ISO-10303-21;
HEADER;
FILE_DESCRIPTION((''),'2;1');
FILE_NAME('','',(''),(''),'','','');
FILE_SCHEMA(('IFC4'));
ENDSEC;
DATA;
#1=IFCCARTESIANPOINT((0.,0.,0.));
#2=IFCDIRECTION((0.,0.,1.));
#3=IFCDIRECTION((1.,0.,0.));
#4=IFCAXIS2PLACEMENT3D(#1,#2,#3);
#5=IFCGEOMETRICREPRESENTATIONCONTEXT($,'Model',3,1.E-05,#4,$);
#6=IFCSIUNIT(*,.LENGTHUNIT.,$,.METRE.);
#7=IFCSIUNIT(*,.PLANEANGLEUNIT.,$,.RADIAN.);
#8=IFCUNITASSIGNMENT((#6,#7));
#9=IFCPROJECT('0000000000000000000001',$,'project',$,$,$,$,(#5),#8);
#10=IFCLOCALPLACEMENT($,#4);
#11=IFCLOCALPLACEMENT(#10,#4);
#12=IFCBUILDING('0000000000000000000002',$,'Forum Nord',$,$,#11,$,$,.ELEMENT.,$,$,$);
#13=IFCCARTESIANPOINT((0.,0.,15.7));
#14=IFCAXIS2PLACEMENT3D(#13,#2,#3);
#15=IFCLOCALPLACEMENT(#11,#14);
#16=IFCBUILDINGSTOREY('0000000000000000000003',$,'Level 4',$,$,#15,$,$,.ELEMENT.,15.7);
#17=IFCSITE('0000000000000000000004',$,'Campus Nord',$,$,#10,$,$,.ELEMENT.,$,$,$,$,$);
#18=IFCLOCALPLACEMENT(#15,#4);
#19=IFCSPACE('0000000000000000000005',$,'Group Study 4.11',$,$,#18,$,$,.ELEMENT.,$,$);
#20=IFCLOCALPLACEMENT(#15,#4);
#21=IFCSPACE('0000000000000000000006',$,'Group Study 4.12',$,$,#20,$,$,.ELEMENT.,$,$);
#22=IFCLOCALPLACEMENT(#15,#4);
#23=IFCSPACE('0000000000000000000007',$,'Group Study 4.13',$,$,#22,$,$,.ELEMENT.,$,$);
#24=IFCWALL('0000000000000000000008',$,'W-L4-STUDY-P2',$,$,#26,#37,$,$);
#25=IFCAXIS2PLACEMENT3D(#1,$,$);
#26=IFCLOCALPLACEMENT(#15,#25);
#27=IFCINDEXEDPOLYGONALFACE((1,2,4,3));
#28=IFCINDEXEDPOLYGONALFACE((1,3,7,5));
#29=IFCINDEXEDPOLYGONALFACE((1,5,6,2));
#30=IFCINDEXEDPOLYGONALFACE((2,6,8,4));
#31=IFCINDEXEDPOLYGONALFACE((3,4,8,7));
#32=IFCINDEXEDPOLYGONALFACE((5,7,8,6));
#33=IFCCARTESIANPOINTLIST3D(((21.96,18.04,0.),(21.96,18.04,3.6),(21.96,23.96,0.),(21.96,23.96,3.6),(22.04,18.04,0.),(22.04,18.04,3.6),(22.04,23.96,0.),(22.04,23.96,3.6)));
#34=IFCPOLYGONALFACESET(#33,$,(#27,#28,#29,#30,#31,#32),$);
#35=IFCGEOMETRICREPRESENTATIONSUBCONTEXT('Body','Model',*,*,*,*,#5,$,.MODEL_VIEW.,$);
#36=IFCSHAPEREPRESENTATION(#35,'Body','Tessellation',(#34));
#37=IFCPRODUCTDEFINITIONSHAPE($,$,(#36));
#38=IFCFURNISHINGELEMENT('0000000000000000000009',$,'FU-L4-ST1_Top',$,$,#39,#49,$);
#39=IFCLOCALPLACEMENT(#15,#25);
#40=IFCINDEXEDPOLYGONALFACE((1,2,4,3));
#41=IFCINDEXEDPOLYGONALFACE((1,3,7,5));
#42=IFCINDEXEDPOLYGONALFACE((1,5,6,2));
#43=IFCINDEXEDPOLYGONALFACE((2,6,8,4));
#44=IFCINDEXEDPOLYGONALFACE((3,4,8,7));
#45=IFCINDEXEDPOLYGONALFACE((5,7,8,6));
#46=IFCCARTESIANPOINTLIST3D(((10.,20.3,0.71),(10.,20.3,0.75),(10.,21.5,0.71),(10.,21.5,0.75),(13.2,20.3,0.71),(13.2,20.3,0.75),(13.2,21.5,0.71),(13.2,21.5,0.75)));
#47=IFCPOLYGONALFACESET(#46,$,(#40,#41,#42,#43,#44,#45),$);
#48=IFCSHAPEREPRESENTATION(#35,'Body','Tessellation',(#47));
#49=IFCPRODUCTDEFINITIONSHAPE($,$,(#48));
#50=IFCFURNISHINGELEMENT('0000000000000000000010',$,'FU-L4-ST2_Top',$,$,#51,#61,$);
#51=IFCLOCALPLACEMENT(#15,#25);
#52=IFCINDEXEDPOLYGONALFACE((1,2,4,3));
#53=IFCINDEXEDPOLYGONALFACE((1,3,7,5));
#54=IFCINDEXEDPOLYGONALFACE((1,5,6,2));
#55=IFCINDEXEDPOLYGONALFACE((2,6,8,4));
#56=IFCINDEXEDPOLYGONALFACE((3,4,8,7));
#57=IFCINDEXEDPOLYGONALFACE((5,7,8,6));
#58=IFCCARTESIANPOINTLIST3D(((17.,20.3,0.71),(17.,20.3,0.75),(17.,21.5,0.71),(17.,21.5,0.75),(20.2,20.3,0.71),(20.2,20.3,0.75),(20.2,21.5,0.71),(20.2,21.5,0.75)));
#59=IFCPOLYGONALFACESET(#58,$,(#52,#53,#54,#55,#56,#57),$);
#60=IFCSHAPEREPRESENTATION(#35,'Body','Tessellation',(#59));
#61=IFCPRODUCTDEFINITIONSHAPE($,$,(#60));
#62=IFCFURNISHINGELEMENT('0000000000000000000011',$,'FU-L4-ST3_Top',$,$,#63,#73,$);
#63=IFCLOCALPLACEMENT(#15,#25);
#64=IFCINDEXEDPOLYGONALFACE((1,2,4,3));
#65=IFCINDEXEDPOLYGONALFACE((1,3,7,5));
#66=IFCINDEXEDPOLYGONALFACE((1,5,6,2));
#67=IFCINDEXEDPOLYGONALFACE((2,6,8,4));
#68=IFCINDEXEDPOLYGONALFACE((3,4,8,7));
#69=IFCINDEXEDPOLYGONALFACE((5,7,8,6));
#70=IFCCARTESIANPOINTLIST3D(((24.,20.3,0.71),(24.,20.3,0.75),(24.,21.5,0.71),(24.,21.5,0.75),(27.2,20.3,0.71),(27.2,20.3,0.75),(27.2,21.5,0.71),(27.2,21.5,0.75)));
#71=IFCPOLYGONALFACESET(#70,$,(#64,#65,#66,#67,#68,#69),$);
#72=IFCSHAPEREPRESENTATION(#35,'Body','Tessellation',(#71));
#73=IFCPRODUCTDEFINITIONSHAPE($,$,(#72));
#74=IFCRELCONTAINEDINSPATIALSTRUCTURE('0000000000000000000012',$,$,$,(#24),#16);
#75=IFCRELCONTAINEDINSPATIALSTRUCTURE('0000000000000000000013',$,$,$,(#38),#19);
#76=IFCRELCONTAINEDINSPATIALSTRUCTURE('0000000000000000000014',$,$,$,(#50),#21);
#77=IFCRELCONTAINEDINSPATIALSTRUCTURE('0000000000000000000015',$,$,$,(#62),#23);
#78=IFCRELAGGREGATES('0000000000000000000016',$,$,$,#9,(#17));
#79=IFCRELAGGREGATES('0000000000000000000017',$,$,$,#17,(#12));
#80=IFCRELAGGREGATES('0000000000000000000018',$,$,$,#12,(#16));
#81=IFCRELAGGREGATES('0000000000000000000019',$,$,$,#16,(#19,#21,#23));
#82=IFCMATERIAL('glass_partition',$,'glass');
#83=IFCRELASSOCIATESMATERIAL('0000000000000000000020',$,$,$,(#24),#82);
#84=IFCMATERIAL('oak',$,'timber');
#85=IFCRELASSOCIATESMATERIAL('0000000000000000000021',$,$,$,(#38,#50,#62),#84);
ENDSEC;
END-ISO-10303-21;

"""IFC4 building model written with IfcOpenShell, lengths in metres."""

from ifc_helpers import new_model, si_unit, frame, frame_2d, origin_with_axes, place, context, subcontext, project, spatial, polyline, rectangle, outline, extrude, material, element, save


model = new_model("IFC4")

# Units and contexts
model_context = context("Model", 3, precision=1e-05, world=origin_with_axes())
body_context = subcontext(model_context, "Body", "Model", "MODEL_VIEW")
ifc_project = project(units=[si_unit("LENGTHUNIT", "METRE"), si_unit("PLANEANGLEUNIT", "RADIAN")], contexts=[model_context])

# Site, building, storey
site_placement = place(None, origin_with_axes())
site = spatial("IfcSite", under=ifc_project, at=site_placement, Name="Campus Nord", CompositionType="ELEMENT")
building_placement = place(site_placement, origin_with_axes())
building = spatial("IfcBuilding", under=site, at=building_placement, Name="Forum Nord", CompositionType="ELEMENT")
storey_placement = place(building_placement, frame((0.0, 0.0, 15.7), z_axis=(0.0, 0.0, 1.0), x_axis=(1.0, 0.0, 0.0)))
storey = spatial("IfcBuildingStorey", under=building, at=storey_placement, Name="Level 4", CompositionType="ELEMENT", Elevation=15.7)

# Wall
ifc_material_1 = material(Name="glass_partition", Category="glass")
wall_placement = place(storey_placement, frame((22.0, 18.0, 0.0), z_axis=(0.0, 0.0, 1.0), x_axis=(0.0, 1.0, 0.0)))
element("IfcWall", 1, at=wall_placement, inside=storey, material=ifc_material_1, Name="W-L4-STUDY-P2", context=body_context, shape_type="SweptSolid", body=[
    extrude(outline(polyline([(0.04, -0.04), (5.96, -0.04), (5.96, 0.04), (0.04, 0.04), (0.04, -0.04)])), origin_with_axes(), (0.0, 0.0, 1.0), 3.6),
])

# Shared definitions
space_1_placement = place(storey_placement, origin_with_axes())
space_1 = spatial("IfcSpace", under=storey, at=space_1_placement, Name="Group Study 4.11", CompositionType="ELEMENT")

# Furnishing element
ifc_material_2 = material(Name="oak", Category="timber")
furnishing_1_placement = place(storey_placement, frame((10.0, 19.8, 0.0), z_axis=(0.0, 0.0, 1.0), x_axis=(1.0, 0.0, 0.0)))
element("IfcFurnishingElement", 2, at=furnishing_1_placement, inside=space_1, material=ifc_material_2, Name="FU-L4-ST1_Top", context=body_context, shape_type="SweptSolid", body=[
    extrude(rectangle(XDim=3.2, YDim=1.2, at=frame_2d((1.6, 1.1), x_axis=(1.0, 0.0))), frame((0.0, 0.0, 0.71), z_axis=(0.0, 0.0, 1.0), x_axis=(1.0, 0.0, 0.0)), (0.0, 0.0, 1.0), 0.04),
])

# Shared definitions
space_2_placement = place(storey_placement, origin_with_axes())
space_2 = spatial("IfcSpace", under=storey, at=space_2_placement, Name="Group Study 4.12", CompositionType="ELEMENT")

# Furnishing element
furnishing_2_placement = place(storey_placement, frame((17.0, 19.8, 0.0), z_axis=(0.0, 0.0, 1.0), x_axis=(1.0, 0.0, 0.0)))
element("IfcFurnishingElement", 3, at=furnishing_2_placement, inside=space_2, material=ifc_material_2, Name="FU-L4-ST2_Top", context=body_context, shape_type="SweptSolid", body=[
    extrude(rectangle(XDim=3.2, YDim=1.2, at=frame_2d((1.6, 1.1), x_axis=(1.0, 0.0))), frame((0.0, 0.0, 0.71), z_axis=(0.0, 0.0, 1.0), x_axis=(1.0, 0.0, 0.0)), (0.0, 0.0, 1.0), 0.04),
])

# Shared definitions
space_3_placement = place(storey_placement, origin_with_axes())
space_3 = spatial("IfcSpace", under=storey, at=space_3_placement, Name="Group Study 4.13", CompositionType="ELEMENT")

# Furnishing element
furnishing_3_placement = place(storey_placement, frame((24.0, 19.8, 0.0), z_axis=(0.0, 0.0, 1.0), x_axis=(1.0, 0.0, 0.0)))
element("IfcFurnishingElement", 4, at=furnishing_3_placement, inside=space_3, material=ifc_material_2, Name="FU-L4-ST3_Top", context=body_context, shape_type="SweptSolid", body=[
    extrude(rectangle(XDim=3.2, YDim=1.2, at=frame_2d((1.6, 1.1), x_axis=(1.0, 0.0))), frame((0.0, 0.0, 0.71), z_axis=(0.0, 0.0, 1.0), x_axis=(1.0, 0.0, 0.0)), (0.0, 0.0, 1.0), 0.04),
])

save(model, "model.ifc")
